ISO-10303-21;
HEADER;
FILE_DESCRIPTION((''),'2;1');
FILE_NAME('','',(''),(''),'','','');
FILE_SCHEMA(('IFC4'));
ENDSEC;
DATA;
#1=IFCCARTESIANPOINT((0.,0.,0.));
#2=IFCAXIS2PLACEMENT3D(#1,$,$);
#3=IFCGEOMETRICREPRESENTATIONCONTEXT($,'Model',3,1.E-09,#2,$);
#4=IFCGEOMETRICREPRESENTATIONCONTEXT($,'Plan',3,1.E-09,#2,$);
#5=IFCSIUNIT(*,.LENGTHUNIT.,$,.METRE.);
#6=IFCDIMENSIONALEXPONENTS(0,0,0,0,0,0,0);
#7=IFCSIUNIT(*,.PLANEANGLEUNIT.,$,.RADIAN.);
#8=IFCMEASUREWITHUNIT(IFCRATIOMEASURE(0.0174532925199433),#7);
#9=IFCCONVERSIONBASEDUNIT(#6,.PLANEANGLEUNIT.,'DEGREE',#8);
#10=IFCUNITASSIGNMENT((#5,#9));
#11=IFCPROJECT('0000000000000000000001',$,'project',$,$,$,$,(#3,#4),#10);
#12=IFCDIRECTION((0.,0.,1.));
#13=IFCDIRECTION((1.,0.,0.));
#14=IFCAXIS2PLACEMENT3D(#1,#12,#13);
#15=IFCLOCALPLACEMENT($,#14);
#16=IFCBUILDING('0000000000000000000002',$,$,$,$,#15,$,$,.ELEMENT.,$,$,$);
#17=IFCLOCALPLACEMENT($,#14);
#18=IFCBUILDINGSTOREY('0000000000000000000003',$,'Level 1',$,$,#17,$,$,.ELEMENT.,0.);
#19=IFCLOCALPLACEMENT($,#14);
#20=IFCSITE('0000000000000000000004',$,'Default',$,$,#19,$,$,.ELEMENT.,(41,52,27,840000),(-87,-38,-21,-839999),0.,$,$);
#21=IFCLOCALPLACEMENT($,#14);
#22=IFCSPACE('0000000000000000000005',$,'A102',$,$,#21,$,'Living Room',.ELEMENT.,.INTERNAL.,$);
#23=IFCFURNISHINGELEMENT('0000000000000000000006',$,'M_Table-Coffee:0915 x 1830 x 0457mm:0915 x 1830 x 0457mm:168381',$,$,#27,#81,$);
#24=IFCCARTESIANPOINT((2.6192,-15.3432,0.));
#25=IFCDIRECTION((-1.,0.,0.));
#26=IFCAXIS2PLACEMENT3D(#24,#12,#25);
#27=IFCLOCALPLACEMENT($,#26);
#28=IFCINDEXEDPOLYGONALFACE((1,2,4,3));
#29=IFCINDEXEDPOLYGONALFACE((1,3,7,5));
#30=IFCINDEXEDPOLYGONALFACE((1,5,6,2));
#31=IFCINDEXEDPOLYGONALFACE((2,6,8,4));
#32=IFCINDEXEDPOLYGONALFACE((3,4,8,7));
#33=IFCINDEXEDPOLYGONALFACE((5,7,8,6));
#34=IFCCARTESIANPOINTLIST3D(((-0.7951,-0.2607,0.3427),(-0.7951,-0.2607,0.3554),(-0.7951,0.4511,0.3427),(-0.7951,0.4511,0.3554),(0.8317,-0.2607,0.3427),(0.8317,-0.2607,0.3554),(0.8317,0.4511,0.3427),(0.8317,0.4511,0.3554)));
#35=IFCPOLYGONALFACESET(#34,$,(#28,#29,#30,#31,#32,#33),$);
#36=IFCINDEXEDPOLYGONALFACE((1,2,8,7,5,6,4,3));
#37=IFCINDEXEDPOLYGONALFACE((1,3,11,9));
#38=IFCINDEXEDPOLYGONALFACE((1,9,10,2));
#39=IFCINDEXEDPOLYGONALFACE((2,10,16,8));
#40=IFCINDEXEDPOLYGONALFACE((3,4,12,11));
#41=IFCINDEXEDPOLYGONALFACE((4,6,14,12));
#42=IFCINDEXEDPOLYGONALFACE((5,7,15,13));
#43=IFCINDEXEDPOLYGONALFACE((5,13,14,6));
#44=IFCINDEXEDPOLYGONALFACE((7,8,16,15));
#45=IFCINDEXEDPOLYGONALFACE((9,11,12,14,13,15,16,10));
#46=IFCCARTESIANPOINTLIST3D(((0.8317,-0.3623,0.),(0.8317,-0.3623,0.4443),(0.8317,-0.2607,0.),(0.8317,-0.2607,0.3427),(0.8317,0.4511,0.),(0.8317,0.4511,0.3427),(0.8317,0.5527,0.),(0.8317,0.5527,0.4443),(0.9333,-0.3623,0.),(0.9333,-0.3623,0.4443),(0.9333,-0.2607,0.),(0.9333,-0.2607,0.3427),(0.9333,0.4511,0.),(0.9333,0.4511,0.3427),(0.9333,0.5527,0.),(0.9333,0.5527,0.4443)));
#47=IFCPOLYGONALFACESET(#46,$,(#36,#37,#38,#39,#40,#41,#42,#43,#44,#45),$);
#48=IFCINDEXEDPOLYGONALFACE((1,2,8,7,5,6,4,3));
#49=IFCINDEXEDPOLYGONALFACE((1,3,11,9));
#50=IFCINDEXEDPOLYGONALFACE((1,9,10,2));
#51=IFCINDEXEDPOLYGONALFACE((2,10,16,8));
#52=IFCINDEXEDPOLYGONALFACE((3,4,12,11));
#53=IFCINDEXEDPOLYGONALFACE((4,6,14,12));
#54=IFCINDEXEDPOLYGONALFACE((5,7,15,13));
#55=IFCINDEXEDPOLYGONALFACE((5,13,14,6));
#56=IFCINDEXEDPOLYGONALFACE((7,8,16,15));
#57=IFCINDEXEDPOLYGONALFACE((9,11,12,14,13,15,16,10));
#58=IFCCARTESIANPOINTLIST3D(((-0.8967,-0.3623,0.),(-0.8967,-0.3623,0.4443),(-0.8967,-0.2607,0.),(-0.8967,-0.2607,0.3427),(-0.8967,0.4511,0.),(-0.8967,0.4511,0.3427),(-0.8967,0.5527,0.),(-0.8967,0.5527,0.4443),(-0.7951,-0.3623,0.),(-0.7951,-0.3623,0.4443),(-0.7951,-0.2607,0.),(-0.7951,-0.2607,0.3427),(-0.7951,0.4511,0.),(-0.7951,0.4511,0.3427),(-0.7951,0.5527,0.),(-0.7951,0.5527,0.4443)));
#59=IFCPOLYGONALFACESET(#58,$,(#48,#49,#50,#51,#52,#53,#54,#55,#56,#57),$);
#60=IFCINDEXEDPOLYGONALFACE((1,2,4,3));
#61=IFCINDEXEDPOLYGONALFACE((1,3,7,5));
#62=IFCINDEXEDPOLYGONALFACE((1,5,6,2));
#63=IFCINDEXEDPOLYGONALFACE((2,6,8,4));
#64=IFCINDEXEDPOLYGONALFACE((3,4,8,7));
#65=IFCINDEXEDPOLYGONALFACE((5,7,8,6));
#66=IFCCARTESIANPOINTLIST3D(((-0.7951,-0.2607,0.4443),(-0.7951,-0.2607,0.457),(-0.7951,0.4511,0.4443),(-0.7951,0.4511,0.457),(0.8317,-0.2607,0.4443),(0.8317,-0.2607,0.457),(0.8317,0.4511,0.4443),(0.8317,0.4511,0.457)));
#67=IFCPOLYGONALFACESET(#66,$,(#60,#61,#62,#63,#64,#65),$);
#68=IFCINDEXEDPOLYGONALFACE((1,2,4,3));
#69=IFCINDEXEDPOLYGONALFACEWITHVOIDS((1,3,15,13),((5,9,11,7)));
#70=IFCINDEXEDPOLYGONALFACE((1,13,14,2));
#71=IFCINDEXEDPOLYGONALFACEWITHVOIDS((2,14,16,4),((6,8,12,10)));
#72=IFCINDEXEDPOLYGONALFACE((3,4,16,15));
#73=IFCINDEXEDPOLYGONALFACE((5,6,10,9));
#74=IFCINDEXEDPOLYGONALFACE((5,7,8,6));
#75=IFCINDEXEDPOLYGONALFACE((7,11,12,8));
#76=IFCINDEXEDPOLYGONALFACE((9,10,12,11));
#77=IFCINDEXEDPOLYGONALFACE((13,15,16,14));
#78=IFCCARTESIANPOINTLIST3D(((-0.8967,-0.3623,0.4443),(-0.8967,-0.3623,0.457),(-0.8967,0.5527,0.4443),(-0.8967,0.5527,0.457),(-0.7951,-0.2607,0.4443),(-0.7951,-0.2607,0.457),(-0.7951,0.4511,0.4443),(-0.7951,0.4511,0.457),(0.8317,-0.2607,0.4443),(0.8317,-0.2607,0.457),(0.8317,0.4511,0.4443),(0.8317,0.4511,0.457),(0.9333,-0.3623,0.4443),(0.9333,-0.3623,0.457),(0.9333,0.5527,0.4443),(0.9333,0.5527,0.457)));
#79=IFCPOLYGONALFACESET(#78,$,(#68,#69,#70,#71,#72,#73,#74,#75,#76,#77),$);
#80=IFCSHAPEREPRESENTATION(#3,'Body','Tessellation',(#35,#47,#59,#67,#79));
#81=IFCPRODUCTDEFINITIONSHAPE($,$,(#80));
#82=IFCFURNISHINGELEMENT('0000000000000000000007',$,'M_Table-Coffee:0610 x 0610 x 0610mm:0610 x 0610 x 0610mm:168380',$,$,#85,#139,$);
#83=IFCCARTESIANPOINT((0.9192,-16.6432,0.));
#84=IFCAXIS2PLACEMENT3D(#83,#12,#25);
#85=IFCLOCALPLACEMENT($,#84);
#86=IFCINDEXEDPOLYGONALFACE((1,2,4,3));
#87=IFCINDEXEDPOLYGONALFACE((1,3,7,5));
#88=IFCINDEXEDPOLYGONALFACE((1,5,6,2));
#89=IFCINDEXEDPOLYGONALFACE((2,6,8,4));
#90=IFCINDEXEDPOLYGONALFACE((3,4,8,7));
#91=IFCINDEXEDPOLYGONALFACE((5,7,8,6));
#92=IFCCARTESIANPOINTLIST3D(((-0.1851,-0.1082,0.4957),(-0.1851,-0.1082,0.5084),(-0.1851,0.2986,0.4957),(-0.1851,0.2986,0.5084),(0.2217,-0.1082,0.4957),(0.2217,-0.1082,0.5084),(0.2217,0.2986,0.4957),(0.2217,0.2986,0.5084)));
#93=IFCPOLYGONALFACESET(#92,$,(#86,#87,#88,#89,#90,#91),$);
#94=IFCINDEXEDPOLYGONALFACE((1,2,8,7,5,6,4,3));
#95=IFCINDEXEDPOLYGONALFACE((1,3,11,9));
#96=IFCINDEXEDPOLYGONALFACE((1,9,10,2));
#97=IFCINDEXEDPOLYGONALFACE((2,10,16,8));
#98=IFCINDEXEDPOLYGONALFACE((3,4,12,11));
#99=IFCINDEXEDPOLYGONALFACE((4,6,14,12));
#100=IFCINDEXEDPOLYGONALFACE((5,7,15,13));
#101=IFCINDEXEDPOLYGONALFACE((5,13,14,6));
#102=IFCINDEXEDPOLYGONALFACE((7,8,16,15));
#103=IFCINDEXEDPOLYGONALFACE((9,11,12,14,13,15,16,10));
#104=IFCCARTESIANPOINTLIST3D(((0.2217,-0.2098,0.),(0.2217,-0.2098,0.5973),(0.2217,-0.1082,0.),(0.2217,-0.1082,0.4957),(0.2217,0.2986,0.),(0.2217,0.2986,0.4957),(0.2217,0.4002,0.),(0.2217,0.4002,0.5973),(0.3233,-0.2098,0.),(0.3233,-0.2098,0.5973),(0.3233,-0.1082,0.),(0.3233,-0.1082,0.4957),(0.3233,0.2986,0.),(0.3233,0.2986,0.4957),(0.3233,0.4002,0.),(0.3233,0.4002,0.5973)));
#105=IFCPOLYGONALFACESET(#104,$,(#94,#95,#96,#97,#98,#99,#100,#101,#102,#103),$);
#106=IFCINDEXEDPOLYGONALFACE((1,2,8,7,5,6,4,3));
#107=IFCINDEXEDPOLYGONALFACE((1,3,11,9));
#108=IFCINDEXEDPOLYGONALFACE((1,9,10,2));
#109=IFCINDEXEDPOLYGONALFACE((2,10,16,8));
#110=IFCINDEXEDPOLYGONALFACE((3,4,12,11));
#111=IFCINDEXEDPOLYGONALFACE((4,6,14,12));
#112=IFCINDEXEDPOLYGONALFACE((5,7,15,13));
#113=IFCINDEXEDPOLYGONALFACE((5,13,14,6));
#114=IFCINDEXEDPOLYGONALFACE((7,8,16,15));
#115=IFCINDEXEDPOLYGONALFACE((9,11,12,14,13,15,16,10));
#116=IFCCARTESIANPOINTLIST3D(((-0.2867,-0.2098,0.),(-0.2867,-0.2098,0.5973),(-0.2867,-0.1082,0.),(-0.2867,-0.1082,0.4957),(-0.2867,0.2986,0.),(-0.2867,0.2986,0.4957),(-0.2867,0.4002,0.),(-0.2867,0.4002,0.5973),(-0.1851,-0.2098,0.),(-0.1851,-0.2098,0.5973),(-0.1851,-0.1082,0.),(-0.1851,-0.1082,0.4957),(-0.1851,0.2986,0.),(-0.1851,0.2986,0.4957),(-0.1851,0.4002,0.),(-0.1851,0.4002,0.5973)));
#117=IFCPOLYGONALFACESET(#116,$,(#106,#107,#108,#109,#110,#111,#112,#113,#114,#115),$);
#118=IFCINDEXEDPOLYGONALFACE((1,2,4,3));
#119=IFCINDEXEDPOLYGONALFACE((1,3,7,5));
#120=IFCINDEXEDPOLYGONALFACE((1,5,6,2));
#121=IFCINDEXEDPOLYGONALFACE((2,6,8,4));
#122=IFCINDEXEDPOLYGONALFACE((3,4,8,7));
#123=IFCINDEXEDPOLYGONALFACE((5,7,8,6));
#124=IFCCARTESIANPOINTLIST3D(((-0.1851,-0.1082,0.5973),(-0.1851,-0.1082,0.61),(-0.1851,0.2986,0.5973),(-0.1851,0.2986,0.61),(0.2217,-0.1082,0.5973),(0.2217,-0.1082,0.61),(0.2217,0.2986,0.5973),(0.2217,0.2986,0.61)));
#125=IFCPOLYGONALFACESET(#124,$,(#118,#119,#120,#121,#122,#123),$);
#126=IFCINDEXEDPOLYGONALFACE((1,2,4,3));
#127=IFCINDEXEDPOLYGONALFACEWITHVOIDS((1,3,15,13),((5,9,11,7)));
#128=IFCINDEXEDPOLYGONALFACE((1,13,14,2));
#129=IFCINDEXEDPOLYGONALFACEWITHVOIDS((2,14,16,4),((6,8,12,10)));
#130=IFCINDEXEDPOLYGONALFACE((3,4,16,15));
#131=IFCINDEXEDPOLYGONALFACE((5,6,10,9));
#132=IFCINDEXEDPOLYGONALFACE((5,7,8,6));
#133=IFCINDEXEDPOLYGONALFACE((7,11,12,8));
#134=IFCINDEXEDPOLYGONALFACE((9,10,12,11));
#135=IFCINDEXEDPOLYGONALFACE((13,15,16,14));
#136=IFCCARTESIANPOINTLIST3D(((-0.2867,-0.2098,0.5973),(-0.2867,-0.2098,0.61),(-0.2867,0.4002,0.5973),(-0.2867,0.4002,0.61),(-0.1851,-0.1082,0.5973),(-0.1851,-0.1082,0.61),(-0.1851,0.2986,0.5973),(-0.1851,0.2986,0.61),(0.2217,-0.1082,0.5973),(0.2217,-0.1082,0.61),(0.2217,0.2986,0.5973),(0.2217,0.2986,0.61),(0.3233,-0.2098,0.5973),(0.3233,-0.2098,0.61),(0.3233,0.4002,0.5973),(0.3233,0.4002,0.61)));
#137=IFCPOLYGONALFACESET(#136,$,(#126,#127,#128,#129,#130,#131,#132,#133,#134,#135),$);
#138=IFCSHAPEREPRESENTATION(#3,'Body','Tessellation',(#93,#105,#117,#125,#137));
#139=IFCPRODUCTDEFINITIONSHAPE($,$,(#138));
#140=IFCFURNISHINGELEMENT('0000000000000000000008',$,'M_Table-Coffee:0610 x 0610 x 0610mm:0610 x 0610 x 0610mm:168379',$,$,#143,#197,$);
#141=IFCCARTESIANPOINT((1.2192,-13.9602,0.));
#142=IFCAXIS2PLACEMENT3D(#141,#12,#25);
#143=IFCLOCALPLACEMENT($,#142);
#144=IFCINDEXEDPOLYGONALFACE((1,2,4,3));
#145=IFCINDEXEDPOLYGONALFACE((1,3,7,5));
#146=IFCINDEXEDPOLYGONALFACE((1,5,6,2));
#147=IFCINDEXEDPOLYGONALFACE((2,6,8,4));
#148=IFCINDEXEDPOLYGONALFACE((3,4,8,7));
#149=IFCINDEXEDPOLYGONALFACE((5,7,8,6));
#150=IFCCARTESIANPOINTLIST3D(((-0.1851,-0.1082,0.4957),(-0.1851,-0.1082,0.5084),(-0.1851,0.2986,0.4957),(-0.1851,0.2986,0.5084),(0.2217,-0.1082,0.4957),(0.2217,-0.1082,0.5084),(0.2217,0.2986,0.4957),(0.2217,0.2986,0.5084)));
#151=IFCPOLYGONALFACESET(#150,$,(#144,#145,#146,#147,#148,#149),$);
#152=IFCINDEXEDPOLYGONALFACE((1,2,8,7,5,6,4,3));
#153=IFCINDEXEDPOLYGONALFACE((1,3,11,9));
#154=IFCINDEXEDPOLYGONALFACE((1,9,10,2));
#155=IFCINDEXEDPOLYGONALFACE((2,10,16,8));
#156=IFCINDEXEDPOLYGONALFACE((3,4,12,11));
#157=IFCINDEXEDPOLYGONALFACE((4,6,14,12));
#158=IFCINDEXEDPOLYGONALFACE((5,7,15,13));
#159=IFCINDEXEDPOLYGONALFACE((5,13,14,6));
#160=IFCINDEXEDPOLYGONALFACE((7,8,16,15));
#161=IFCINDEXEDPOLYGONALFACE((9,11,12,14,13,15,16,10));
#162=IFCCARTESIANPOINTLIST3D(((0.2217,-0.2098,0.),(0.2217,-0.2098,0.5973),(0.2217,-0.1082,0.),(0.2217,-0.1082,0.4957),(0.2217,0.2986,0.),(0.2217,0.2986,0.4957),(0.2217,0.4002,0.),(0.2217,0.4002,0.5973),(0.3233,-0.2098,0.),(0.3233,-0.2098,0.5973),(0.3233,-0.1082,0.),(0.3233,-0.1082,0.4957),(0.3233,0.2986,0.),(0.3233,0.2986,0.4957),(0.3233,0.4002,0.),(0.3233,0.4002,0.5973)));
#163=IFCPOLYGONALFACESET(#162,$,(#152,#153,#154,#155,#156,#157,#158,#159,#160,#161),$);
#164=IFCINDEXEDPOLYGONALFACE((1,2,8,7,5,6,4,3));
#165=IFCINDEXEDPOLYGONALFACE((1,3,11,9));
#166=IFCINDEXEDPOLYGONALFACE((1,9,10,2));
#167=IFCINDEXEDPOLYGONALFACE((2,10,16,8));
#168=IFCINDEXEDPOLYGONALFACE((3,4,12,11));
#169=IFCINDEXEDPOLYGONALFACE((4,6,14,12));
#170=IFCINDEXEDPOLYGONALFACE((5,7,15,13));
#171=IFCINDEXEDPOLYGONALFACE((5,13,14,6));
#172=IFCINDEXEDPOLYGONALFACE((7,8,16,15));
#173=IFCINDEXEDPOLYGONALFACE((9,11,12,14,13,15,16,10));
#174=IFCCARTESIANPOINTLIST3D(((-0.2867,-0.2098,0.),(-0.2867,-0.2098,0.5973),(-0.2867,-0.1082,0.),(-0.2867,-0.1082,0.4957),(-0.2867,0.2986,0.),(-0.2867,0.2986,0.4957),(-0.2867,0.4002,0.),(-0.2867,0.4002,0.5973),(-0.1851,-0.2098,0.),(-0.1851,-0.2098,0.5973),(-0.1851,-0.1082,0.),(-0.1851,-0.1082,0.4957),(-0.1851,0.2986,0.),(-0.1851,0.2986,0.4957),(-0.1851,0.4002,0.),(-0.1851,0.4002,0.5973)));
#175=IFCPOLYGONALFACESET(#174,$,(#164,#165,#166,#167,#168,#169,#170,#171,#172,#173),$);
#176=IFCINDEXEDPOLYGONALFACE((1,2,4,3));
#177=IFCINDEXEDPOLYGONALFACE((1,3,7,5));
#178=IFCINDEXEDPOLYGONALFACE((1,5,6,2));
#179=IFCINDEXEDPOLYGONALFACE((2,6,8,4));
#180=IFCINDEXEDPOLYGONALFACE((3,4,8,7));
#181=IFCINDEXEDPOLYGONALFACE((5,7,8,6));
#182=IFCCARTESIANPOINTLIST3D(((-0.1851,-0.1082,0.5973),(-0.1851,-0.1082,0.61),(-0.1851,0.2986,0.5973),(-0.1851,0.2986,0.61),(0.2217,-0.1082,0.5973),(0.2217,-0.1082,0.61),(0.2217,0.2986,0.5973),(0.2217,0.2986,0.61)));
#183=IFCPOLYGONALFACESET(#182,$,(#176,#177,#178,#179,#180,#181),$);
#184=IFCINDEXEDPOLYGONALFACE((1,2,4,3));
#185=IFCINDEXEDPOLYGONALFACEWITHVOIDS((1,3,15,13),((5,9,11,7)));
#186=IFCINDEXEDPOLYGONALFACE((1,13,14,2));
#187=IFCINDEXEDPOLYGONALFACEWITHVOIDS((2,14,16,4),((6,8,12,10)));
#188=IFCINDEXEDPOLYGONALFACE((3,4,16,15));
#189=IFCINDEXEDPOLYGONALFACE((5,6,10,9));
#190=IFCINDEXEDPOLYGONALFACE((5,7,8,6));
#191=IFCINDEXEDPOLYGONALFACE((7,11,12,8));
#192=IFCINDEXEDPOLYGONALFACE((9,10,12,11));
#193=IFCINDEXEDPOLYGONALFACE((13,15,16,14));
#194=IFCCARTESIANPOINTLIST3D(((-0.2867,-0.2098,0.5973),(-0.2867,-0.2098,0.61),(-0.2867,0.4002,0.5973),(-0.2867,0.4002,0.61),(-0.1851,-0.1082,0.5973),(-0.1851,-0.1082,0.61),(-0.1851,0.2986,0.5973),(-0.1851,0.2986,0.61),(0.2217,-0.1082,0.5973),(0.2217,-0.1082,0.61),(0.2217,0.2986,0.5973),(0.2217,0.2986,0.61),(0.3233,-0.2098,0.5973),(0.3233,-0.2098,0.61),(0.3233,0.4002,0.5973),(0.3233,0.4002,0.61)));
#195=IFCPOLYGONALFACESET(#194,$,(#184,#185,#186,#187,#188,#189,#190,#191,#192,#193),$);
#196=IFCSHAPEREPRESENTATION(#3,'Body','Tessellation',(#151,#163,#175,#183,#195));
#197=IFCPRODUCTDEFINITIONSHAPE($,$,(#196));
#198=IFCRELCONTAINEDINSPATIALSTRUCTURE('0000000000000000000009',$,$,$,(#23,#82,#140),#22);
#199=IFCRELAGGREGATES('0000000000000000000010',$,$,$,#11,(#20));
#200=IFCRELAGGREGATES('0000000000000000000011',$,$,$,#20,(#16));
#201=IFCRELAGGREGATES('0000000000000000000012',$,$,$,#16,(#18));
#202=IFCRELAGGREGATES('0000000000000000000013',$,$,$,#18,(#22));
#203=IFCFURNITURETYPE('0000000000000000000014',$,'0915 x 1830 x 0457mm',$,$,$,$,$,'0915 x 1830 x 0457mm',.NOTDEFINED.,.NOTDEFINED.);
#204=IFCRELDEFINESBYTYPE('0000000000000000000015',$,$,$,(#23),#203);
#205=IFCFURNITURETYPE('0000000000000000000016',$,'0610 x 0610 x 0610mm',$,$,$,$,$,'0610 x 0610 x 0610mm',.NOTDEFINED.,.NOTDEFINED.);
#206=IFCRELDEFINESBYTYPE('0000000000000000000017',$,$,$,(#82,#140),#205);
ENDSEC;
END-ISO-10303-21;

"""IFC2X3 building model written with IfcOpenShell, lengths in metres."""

from ifc_helpers import new_model, entity, si_unit, converted_unit, frame, origin, origin_with_axes, origin_2d_with_axis, place, context, project, spatial, polyline, rectangle, outline, extrude, source, transform, mapped, type_object, type_shapes, element, save


model = new_model("IFC2X3")

# Units and contexts
model_context = context("Model", 3, precision=1e-09, world=origin())
plan_context = context("Plan", 3, precision=1e-09, world=origin())
ifc_project = project(units=[si_unit("LENGTHUNIT", "METRE"), converted_unit("PLANEANGLEUNIT", "DEGREE", entity("IfcRatioMeasure", 0.0174532925199433), si_unit("PLANEANGLEUNIT", "RADIAN"), dimensions=[0, 0, 0, 0, 0, 0, 0])], contexts=[model_context, plan_context])

# Site, building, storey, space
site_placement = place(None, origin_with_axes())
site = spatial("IfcSite", under=ifc_project, at=site_placement, Name="Default", CompositionType="ELEMENT", RefLatitude=(41, 52, 27, 840000), RefLongitude=(-87, -38, -21, -839999), RefElevation=0.0)
building_placement = place(None, origin_with_axes())
building = spatial("IfcBuilding", under=site, at=building_placement, CompositionType="ELEMENT")
storey_placement = place(None, origin_with_axes())
storey = spatial("IfcBuildingStorey", under=building, at=storey_placement, Name="Level 1", CompositionType="ELEMENT", Elevation=0.0)
space_placement = place(None, origin_with_axes())
space = spatial("IfcSpace", under=storey, at=space_placement, Name="A102", LongName="Living Room", CompositionType="ELEMENT", InteriorOrExteriorSpace="INTERNAL")

# Furnishing elements
furniture_type_1 = type_object("IfcFurnitureType", Name="0915 x 1830 x 0457mm", ElementType="0915 x 1830 x 0457mm", AssemblyPlace="NOTDEFINED")
shared_shape_1 = source(origin(), model_context, "Body", "SweptSolid", [
    extrude(rectangle(XDim=1.6268, YDim=0.7118, at=origin_2d_with_axis()), frame((0.0183, 0.0952, 0.3427), z_axis=(0.0, 0.0, 1.0), x_axis=(-1.0, 0.0, 0.0)), (0.0, 0.0, 1.0), 0.0127),
    extrude(outline(polyline([(-0.1967, -0.4575), (0.2475, -0.4575), (0.2475, 0.4575), (-0.1967, 0.4575), (-0.1967, 0.3559), (0.146, 0.3559), (0.146, -0.3559), (-0.1967, -0.3559), (-0.1967, -0.4575)])), frame((0.8317, 0.0952, 0.1967), z_axis=(1.0, 0.0, 0.0), x_axis=(0.0, 0.0, 1.0)), (0.0, 0.0, 1.0), 0.1016),
    extrude(outline(polyline([(-0.4575, -0.2476), (0.4575, -0.2476), (0.4575, 0.1968), (0.3559, 0.1968), (0.3559, -0.1459), (-0.3559, -0.1459), (-0.3559, 0.1968), (-0.4575, 0.1968), (-0.4575, -0.2476)])), frame((-0.8967, 0.0952, 0.1968), z_axis=(1.0, 0.0, 0.0), x_axis=(0.0, -1.0, 0.0)), (0.0, 0.0, 1.0), 0.1016),
    extrude(rectangle(XDim=1.6268, YDim=0.7118, at=origin_2d_with_axis()), frame((0.0183, 0.0952, 0.4443), z_axis=(0.0, 0.0, 1.0), x_axis=(-1.0, 0.0, 0.0)), (0.0, 0.0, 1.0), 0.0127),
    extrude(outline(polyline([(-0.915, -0.4575), (0.915, -0.4575), (0.915, 0.4575), (-0.915, 0.4575), (-0.915, -0.4575)]), holes=[polyline([(-0.8134, -0.3559), (-0.8134, 0.3559), (0.8134, 0.3559), (0.8134, -0.3559), (-0.8134, -0.3559)])]), frame((0.0183, 0.0952, 0.4443), z_axis=(0.0, 0.0, 1.0), x_axis=(-1.0, 0.0, 0.0)), (0.0, 0.0, 1.0), 0.0127),
])
type_shapes(furniture_type_1, [shared_shape_1])
furnishing_placement = place(None, frame((2.6192, -15.3432, 0.0), z_axis=(0.0, 0.0, 1.0), x_axis=(-1.0, 0.0, 0.0)))
element("IfcFurnishingElement", 1, at=furnishing_placement, inside=space, type_object=furniture_type_1, Name="M_Table-Coffee:0915 x 1830 x 0457mm:0915 x 1830 x 0457mm:168381", context=model_context, shape_type="MappedRepresentation", body=[
    mapped(shared_shape_1, transform((0.0, 0.0, 0.0), scale=1.0)),
])
furniture_type_2 = type_object("IfcFurnitureType", Name="0610 x 0610 x 0610mm", ElementType="0610 x 0610 x 0610mm", AssemblyPlace="NOTDEFINED")
shared_shape_2 = source(origin(), model_context, "Body", "SweptSolid", [
    extrude(rectangle(XDim=0.4068, YDim=0.4068, at=origin_2d_with_axis()), frame((0.0183, 0.0952, 0.4957), z_axis=(0.0, 0.0, 1.0), x_axis=(-1.0, 0.0, 0.0)), (0.0, 0.0, 1.0), 0.0127),
    extrude(outline(polyline([(-0.2732, -0.305), (0.324, -0.305), (0.324, 0.305), (-0.2732, 0.305), (-0.2732, 0.2034), (0.2225, 0.2034), (0.2225, -0.2034), (-0.2732, -0.2034), (-0.2732, -0.305)])), frame((0.2217, 0.0952, 0.2732), z_axis=(1.0, 0.0, 0.0), x_axis=(0.0, 0.0, 1.0)), (0.0, 0.0, 1.0), 0.1016),
    extrude(outline(polyline([(-0.305, -0.3241), (0.305, -0.3241), (0.305, 0.2733), (0.2034, 0.2733), (0.2034, -0.2224), (-0.2034, -0.2224), (-0.2034, 0.2733), (-0.305, 0.2733), (-0.305, -0.3241)])), frame((-0.2867, 0.0952, 0.2733), z_axis=(1.0, 0.0, 0.0), x_axis=(0.0, -1.0, 0.0)), (0.0, 0.0, 1.0), 0.1016),
    extrude(rectangle(XDim=0.4068, YDim=0.4068, at=origin_2d_with_axis()), frame((0.0183, 0.0952, 0.5973), z_axis=(0.0, 0.0, 1.0), x_axis=(-1.0, 0.0, 0.0)), (0.0, 0.0, 1.0), 0.0127),
    extrude(outline(polyline([(-0.305, -0.305), (0.305, -0.305), (0.305, 0.305), (-0.305, 0.305), (-0.305, -0.305)]), holes=[polyline([(-0.2034, -0.2034), (-0.2034, 0.2034), (0.2034, 0.2034), (0.2034, -0.2034), (-0.2034, -0.2034)])]), frame((0.0183, 0.0952, 0.5973), z_axis=(0.0, 0.0, 1.0), x_axis=(-1.0, 0.0, 0.0)), (0.0, 0.0, 1.0), 0.0127),
])
type_shapes(furniture_type_2, [shared_shape_2])
for number, where, z_axis, x_axis, name in (
    (2, (0.9192, -16.6432, 0.0), (0.0, 0.0, 1.0), (-1.0, 0.0, 0.0), "M_Table-Coffee:0610 x 0610 x 0610mm:0610 x 0610 x 0610mm:168380"),
    (3, (1.2192, -13.9602, 0.0), (0.0, 0.0, 1.0), (-1.0, 0.0, 0.0), "M_Table-Coffee:0610 x 0610 x 0610mm:0610 x 0610 x 0610mm:168379"),
):
    element("IfcFurnishingElement", number, at=place(None, frame(where, z_axis=z_axis, x_axis=x_axis)), inside=space, type_object=furniture_type_2, Name=name, context=model_context, shape_type="MappedRepresentation", body=[
        mapped(shared_shape_2, transform((0.0, 0.0, 0.0), scale=1.0)),
    ])

save(model, "model.ifc")
